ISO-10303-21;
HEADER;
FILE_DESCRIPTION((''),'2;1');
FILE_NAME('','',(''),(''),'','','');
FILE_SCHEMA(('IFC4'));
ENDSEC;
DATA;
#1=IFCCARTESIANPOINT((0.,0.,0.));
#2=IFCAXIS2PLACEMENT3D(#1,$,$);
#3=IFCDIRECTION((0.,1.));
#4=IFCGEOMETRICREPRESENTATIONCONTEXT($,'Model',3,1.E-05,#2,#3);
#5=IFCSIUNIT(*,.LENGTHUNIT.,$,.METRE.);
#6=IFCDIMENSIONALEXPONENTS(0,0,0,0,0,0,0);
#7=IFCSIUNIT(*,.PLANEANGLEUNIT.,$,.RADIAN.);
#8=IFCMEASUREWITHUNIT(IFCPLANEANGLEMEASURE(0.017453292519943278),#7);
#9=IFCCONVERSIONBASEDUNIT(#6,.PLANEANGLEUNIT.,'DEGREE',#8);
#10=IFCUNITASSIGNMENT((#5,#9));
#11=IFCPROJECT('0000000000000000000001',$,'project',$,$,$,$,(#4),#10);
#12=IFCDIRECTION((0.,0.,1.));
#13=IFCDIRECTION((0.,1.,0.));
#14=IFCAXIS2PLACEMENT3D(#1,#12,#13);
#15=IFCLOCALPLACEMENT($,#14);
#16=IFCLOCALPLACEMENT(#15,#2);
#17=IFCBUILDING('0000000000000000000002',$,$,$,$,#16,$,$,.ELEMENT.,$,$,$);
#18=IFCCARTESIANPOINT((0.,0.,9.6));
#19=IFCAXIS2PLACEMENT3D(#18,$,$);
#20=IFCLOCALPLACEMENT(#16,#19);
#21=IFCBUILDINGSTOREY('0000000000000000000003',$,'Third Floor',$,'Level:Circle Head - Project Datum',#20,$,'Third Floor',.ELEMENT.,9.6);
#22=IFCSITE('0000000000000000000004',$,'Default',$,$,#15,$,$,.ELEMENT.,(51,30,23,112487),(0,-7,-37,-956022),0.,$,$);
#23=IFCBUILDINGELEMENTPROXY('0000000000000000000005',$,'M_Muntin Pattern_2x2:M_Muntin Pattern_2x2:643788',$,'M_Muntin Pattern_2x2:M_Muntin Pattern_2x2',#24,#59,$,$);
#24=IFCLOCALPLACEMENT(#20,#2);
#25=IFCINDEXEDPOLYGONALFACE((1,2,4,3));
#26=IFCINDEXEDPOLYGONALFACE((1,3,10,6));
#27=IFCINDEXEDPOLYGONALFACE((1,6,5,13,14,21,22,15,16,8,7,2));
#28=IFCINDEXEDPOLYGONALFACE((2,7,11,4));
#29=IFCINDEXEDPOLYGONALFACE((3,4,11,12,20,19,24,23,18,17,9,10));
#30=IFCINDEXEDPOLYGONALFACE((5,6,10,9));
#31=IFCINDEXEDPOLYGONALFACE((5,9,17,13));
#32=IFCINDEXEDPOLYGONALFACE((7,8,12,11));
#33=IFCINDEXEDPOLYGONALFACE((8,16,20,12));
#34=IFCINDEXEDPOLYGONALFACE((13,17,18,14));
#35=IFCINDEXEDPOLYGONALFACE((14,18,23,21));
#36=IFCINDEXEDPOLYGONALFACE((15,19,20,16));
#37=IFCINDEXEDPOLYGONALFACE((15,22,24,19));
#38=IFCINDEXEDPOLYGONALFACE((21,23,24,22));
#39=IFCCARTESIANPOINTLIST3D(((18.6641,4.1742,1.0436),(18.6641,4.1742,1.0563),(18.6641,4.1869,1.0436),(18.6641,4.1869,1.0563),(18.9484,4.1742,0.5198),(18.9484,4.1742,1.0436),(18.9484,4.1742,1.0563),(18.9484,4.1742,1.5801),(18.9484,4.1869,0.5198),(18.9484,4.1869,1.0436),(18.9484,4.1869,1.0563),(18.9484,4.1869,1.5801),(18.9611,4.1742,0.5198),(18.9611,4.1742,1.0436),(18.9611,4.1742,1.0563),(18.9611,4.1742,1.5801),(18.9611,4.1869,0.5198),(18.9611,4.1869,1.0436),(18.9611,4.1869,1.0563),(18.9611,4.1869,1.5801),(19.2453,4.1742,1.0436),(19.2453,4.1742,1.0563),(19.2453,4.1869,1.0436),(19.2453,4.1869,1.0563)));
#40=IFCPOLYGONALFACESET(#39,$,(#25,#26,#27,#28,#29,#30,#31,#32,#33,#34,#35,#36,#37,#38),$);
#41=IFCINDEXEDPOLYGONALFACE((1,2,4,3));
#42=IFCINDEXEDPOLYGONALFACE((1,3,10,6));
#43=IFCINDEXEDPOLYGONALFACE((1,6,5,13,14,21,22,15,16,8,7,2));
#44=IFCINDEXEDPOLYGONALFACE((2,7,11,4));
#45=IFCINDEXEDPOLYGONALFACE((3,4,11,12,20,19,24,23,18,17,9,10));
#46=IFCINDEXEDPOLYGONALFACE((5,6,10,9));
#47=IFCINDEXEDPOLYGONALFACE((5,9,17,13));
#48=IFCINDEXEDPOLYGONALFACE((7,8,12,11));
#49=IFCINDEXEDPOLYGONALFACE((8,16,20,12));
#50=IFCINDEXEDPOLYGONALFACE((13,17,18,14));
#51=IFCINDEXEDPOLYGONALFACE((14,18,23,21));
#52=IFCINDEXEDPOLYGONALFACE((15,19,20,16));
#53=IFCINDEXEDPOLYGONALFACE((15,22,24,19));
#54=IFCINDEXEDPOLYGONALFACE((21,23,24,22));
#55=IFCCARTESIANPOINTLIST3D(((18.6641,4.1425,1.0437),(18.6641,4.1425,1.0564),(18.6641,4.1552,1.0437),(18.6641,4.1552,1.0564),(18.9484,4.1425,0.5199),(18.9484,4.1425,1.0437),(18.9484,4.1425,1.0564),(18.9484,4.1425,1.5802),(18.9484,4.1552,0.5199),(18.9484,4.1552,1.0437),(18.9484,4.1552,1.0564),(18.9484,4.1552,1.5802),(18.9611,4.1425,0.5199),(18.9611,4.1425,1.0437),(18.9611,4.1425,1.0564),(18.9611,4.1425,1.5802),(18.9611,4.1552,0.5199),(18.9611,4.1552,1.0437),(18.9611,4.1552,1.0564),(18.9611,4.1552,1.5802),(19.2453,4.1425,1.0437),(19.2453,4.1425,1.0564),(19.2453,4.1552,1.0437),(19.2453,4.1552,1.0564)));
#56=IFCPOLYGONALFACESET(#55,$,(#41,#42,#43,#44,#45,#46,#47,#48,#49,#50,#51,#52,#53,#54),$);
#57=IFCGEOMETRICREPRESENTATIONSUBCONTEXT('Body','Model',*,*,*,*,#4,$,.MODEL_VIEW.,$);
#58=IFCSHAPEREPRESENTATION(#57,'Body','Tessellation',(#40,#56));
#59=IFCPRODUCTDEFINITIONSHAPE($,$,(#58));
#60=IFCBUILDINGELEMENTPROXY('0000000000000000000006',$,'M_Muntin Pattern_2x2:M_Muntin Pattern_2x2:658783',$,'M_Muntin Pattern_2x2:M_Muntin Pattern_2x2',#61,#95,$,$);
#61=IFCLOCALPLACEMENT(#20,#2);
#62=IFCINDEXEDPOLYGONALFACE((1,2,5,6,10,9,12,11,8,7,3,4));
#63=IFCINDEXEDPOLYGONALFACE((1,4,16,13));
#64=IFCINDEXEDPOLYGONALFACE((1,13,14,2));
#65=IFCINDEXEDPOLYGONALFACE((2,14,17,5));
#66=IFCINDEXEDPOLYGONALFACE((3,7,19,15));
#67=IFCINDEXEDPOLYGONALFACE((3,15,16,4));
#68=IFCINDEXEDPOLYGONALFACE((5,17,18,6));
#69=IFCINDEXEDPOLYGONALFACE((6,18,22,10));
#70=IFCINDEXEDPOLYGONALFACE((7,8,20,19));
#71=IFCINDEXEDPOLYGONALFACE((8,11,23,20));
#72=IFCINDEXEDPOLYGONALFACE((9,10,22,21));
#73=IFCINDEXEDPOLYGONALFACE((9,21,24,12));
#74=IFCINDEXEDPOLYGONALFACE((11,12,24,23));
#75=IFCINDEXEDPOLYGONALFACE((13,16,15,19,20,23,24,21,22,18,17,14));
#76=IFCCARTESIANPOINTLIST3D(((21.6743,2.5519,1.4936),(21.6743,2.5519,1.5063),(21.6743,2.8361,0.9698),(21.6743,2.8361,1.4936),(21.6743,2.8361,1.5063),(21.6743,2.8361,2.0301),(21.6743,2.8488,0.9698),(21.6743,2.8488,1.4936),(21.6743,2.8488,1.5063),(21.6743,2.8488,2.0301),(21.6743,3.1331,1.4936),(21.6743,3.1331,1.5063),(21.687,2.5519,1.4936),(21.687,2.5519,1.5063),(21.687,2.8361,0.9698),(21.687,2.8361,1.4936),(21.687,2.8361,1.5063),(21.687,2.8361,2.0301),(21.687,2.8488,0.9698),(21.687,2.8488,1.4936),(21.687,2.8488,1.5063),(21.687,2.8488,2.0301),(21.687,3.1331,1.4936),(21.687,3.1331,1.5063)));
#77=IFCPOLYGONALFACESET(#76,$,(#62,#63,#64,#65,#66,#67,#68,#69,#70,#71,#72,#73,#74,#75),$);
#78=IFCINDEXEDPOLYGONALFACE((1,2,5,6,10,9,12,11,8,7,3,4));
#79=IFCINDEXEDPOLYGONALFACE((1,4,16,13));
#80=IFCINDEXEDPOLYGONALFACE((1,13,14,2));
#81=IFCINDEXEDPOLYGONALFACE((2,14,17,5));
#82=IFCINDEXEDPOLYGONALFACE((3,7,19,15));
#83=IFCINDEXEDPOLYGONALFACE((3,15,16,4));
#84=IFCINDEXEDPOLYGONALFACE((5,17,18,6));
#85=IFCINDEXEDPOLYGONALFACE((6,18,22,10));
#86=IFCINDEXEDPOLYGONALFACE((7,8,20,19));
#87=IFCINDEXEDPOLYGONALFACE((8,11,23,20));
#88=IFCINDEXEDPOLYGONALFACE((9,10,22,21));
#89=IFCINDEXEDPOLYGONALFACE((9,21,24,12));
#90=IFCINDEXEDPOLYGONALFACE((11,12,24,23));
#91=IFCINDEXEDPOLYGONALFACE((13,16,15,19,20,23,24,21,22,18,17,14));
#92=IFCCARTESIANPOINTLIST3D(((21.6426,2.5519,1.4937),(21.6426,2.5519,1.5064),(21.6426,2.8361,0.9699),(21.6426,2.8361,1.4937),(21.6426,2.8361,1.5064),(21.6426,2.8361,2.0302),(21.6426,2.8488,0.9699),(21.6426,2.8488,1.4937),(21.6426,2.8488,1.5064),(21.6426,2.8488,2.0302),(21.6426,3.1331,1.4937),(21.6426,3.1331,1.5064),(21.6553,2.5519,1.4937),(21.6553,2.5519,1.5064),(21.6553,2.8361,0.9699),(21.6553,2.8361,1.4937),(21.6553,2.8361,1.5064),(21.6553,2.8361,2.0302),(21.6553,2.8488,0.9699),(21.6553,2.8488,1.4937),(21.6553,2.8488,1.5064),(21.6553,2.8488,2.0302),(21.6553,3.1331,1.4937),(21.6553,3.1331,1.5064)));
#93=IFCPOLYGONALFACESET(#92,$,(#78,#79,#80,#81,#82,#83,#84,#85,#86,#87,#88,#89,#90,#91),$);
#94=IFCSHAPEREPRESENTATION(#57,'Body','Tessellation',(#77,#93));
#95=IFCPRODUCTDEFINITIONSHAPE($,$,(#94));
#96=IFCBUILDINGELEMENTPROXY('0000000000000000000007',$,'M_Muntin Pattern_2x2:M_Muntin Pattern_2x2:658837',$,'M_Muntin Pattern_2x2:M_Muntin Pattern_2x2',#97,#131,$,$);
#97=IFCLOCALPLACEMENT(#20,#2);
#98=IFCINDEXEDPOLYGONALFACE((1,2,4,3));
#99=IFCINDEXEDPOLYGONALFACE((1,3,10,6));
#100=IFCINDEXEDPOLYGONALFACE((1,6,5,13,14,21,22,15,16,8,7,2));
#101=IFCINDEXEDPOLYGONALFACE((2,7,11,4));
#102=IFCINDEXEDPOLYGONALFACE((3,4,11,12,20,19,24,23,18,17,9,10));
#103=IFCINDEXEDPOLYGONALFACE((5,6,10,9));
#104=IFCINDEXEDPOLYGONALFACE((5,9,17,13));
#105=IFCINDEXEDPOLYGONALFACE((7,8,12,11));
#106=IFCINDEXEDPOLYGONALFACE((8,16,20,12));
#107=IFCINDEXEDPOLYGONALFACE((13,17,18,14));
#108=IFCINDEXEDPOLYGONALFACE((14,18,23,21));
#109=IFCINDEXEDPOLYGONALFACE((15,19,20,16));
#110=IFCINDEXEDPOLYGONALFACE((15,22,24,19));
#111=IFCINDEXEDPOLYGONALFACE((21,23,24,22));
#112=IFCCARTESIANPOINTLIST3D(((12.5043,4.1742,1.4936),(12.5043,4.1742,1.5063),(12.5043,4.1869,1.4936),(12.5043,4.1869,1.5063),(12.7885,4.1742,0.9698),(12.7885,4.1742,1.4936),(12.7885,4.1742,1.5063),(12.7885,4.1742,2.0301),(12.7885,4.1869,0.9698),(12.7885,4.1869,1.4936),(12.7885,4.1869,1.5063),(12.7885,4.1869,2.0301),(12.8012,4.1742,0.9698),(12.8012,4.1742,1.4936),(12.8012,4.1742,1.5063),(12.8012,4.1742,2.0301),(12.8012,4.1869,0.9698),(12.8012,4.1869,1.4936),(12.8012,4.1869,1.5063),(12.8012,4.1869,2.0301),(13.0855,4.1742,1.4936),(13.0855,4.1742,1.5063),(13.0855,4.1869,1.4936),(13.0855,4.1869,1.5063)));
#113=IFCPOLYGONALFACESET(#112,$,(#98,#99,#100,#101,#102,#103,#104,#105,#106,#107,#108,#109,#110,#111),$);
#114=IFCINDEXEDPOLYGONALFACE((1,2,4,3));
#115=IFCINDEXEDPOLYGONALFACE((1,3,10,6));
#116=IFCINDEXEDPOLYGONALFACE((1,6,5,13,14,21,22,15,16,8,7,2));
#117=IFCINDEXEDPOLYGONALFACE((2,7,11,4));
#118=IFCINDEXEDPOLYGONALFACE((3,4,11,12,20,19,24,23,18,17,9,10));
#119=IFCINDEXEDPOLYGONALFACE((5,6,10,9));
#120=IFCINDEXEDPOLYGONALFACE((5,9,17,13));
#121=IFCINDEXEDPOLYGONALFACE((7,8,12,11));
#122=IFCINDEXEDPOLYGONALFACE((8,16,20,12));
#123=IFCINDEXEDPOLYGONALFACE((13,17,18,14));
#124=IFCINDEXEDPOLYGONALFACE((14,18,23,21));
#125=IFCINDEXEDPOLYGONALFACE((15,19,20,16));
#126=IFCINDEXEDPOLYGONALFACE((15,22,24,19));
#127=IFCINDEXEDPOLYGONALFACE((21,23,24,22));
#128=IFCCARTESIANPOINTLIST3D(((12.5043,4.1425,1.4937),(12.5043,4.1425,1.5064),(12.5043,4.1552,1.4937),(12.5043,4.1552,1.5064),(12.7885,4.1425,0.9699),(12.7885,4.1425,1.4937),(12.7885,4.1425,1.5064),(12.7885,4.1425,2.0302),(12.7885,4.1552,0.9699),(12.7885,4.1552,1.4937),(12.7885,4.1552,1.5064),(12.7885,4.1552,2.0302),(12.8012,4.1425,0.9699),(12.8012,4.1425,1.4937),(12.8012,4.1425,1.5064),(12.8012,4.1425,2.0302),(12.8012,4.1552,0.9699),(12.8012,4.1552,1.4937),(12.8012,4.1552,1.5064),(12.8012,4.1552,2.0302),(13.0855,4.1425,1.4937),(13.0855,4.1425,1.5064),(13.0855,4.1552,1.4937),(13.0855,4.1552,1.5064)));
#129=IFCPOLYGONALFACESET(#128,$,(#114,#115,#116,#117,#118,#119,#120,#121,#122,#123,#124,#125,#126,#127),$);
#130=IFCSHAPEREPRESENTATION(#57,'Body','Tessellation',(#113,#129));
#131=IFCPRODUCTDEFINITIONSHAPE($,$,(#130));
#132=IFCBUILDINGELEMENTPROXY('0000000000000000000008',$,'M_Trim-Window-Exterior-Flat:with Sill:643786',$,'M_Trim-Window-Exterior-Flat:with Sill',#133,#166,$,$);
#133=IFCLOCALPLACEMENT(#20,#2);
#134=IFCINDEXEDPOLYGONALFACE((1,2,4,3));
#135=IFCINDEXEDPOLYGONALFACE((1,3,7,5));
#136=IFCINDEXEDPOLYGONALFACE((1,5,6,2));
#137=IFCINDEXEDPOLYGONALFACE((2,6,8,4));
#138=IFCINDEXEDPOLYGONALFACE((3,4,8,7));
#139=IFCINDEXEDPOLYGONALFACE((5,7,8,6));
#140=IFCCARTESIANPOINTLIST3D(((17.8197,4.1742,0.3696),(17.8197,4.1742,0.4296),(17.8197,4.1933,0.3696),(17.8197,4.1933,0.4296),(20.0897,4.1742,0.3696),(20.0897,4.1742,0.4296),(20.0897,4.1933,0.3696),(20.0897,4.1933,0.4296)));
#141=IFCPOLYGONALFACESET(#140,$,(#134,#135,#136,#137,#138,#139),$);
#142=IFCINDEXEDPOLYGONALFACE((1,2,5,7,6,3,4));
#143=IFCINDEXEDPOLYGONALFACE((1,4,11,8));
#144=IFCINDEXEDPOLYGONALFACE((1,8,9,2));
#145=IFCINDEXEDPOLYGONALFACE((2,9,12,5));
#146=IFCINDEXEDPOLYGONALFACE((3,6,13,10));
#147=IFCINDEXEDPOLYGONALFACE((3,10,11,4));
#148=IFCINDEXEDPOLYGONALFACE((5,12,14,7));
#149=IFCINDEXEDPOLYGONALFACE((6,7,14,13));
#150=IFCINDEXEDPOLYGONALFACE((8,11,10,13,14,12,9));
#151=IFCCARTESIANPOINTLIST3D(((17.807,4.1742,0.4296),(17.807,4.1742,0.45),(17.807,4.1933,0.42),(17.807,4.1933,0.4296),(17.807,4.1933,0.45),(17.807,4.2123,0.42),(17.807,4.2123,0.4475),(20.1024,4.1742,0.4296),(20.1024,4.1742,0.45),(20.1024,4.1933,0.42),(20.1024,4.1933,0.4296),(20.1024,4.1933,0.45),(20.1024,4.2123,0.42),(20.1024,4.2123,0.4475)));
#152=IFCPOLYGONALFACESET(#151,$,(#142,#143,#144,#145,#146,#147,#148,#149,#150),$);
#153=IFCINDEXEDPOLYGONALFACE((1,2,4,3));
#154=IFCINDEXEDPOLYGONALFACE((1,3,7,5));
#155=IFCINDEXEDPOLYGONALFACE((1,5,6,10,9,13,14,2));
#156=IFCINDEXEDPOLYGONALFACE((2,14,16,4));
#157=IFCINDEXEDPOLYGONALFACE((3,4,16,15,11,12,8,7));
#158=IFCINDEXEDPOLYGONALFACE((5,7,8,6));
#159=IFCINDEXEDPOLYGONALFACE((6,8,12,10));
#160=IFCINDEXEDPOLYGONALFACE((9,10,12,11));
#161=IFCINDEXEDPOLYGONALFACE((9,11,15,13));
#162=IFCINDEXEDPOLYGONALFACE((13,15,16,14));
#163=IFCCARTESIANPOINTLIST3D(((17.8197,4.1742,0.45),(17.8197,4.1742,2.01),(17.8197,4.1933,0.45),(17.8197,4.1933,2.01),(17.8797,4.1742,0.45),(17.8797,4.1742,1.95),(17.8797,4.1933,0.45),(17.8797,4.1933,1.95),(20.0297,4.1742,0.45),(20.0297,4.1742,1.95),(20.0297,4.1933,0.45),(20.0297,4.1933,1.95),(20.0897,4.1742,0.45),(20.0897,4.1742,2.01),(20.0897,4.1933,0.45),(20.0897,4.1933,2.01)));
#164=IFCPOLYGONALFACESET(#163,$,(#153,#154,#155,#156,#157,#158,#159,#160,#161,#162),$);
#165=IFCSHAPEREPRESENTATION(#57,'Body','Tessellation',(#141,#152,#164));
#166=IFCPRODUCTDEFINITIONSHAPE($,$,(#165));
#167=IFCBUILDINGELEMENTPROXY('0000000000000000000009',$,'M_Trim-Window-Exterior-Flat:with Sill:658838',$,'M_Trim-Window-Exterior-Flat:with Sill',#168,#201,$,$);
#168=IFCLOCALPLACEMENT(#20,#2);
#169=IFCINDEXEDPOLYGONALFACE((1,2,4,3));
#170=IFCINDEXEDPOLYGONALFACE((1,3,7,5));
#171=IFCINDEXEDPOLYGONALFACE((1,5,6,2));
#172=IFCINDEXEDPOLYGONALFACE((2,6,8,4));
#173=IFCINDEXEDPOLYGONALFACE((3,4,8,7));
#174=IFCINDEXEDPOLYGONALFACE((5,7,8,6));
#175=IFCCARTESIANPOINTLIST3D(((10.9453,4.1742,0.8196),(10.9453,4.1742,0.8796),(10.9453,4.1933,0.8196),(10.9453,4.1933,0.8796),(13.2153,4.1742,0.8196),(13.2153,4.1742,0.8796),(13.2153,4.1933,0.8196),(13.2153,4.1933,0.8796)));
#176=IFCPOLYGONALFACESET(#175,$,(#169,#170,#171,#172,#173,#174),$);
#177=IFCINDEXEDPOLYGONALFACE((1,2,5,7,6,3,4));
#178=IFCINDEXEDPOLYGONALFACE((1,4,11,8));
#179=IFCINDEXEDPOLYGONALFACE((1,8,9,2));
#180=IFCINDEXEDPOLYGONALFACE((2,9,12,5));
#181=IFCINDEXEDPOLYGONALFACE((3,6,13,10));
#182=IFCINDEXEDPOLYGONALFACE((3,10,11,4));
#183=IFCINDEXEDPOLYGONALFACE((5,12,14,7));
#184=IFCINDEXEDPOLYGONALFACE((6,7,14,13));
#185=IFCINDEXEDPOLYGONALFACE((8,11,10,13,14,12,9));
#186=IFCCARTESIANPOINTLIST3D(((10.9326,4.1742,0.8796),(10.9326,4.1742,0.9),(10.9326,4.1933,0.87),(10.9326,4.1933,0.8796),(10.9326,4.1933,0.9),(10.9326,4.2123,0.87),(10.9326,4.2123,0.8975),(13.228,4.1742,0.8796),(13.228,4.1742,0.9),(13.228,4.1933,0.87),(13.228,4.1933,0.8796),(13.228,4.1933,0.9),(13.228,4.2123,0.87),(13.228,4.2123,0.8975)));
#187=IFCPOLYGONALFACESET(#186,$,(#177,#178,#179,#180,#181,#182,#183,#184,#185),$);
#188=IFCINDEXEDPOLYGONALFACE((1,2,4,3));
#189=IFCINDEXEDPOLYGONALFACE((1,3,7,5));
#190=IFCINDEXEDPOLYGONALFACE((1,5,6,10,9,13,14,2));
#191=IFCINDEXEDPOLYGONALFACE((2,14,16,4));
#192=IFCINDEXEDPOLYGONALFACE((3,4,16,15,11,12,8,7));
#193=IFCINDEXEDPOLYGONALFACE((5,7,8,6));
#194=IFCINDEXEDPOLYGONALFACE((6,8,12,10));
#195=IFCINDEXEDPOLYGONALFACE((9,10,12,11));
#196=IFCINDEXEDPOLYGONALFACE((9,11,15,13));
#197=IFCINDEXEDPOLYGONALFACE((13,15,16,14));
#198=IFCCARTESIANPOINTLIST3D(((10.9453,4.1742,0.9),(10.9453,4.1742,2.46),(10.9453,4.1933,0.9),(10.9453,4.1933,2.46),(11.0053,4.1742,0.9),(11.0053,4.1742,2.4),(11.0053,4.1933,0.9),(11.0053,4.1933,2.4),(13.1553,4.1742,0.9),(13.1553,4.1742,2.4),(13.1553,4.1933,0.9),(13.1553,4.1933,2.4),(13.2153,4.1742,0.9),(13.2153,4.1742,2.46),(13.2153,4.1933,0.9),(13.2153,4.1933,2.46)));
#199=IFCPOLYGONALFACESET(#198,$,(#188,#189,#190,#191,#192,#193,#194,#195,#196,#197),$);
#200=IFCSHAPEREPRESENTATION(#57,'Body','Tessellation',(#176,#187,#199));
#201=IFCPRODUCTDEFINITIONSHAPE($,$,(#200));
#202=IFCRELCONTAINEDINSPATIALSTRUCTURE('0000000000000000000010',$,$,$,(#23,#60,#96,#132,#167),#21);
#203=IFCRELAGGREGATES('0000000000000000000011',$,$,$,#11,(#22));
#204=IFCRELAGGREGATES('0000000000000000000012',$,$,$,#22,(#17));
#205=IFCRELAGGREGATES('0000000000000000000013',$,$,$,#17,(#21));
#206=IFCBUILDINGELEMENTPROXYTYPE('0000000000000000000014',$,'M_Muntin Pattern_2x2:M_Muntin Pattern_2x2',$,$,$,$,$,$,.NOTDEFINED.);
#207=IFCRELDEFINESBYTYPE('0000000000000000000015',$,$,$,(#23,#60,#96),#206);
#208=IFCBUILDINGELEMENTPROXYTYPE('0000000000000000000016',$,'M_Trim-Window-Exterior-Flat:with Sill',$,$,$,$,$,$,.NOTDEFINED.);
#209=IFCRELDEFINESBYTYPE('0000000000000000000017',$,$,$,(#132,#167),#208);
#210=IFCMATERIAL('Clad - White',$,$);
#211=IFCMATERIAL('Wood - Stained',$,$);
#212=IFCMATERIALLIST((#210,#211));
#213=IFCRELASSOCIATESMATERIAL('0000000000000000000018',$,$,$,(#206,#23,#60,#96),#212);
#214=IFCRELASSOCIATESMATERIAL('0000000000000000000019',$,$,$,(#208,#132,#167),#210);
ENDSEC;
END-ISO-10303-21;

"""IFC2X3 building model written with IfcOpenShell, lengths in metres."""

from ifc_helpers import new_model, entity, si_unit, converted_unit, direction, frame, frame_2d, origin, place, context, subcontext, project, spatial, polyline, rectangle, outline, extrude, source, transform, mapped, material, material_list, type_object, type_shapes, element, save


model = new_model("IFC2X3")

# Units and contexts
model_context = context("Model", 3, precision=1e-05, world=origin(), true_north=direction((0.0, 1.0)))
body_context = subcontext(model_context, "Body", "Model", "MODEL_VIEW")
ifc_project = project(units=[si_unit("LENGTHUNIT", "METRE"), converted_unit("PLANEANGLEUNIT", "DEGREE", entity("IfcPlaneAngleMeasure", 0.017453292519943278), si_unit("PLANEANGLEUNIT", "RADIAN"), dimensions=[0, 0, 0, 0, 0, 0, 0])], contexts=[model_context])

# Site, building, storey
site_placement = place(None, frame((0.0, 0.0, 0.0), z_axis=(0.0, 0.0, 1.0), x_axis=(0.0, 1.0, 0.0)))
site = spatial("IfcSite", under=ifc_project, at=site_placement, Name="Default", CompositionType="ELEMENT", RefLatitude=(51, 30, 23, 112487), RefLongitude=(0, -7, -37, -956022), RefElevation=0.0)
building_placement = place(site_placement, origin())
building = spatial("IfcBuilding", under=site, at=building_placement, CompositionType="ELEMENT")
storey_placement = place(building_placement, frame((0.0, 0.0, 9.6)))
storey = spatial("IfcBuildingStorey", under=building, at=storey_placement, Name="Third Floor", ObjectType="Level:Circle Head - Project Datum", LongName="Third Floor", CompositionType="ELEMENT", Elevation=9.6)

# Building element proxies
ifc_material_1 = material(Name="Clad - White")
ifc_material_2 = material(Name="Wood - Stained")
ifc_material_list = material_list([ifc_material_1, ifc_material_2])
building_element_proxy_type_1 = type_object("IfcBuildingElementProxyType", Name="M_Muntin Pattern_2x2:M_Muntin Pattern_2x2", PredefinedType="NOTDEFINED", material=ifc_material_list)
shared_shape_1 = source(origin(), body_context, "Body", "SweptSolid", [
    extrude(outline(polyline([(0.0064, -0.0064), (0.5301, -0.0064), (0.5301, 0.0063), (0.0064, 0.0063), (0.0064, 0.2906), (-0.0063, 0.2906), (-0.0063, 0.0063), (-0.5302, 0.0063), (-0.5302, -0.0064), (-0.0063, -0.0064), (-0.0063, -0.2906), (0.0064, -0.2906), (0.0064, -0.0064)])), frame((0.0, -0.0222, 0.5301), z_axis=(0.0, 1.0, 0.0), x_axis=(0.0, 0.0, 1.0)), (0.0, 0.0, 1.0), 0.0127),
    extrude(outline(polyline([(0.0064, -0.0064), (0.5302, -0.0064), (0.5302, 0.0063), (0.0064, 0.0063), (0.0064, 0.2906), (-0.0063, 0.2906), (-0.0063, 0.0063), (-0.5302, 0.0063), (-0.5302, -0.0064), (-0.0063, -0.0064), (-0.0063, -0.2906), (0.0064, -0.2906), (0.0064, -0.0064)])), frame((0.0, 0.0095, 0.5302), z_axis=(0.0, 1.0, 0.0), x_axis=(0.0, 0.0, 1.0)), (0.0, 0.0, 1.0), 0.0127),
])
type_shapes(building_element_proxy_type_1, [shared_shape_1])
for number, where, z_axis, x_axis, name in (
    (1, (18.9547, 4.1647, 0.5199), (0.0, 0.0, 1.0), (-1.0, 0.0, 0.0), "M_Muntin Pattern_2x2:M_Muntin Pattern_2x2:643788"),
    (2, (21.6648, 2.8425, 0.9699), (0.0, 0.0, 1.0), (0.0, 1.0, 0.0), "M_Muntin Pattern_2x2:M_Muntin Pattern_2x2:658783"),
    (3, (12.7949, 4.1647, 0.9699), (0.0, 0.0, 1.0), (-1.0, 0.0, 0.0), "M_Muntin Pattern_2x2:M_Muntin Pattern_2x2:658837"),
):
    element("IfcBuildingElementProxy", number, at=place(storey_placement, frame(where, z_axis=z_axis, x_axis=x_axis)), inside=storey, type_object=building_element_proxy_type_1, material=ifc_material_list, Name=name, ObjectType="M_Muntin Pattern_2x2:M_Muntin Pattern_2x2", context=body_context, shape_type="MappedRepresentation", body=[
        mapped(shared_shape_1, transform((0.0, 0.0, 0.0), scale=1.0)),
    ])
building_element_proxy_type_2 = type_object("IfcBuildingElementProxyType", Name="M_Trim-Window-Exterior-Flat:with Sill", PredefinedType="NOTDEFINED", material=ifc_material_1)
shared_shape_2 = source(origin(), body_context, "Body", "SweptSolid", [
    extrude(rectangle(XDim=2.27, YDim=0.06, at=frame_2d((0.0, 0.0), x_axis=(1.0, 0.0))), frame((0.0, -1.5504, 0.0), z_axis=(0.0, 0.0, 1.0), x_axis=(-1.0, 0.0, 0.0)), (0.0, 0.0, 1.0), 0.019),
    extrude(outline(polyline([(-0.019, -0.0152), (0.0, -0.0152), (0.0, -0.0057), (0.019, -0.0057), (0.019, 0.0148), (0.0, 0.0148), (-0.019, 0.0123), (-0.019, -0.0152)])), frame((-1.1477, -1.5148, 0.019), z_axis=(1.0, 0.0, 0.0), x_axis=(0.0, 0.0, -1.0)), (0.0, 0.0, 1.0), 2.2954),
    extrude(outline(polyline([(-0.795, -1.135), (0.765, -1.135), (0.765, -1.075), (-0.735, -1.075), (-0.735, 1.075), (0.765, 1.075), (0.765, 1.135), (-0.795, 1.135), (-0.795, -1.135)])), frame((0.0, -0.735, 0.0), z_axis=(0.0, 0.0, 1.0), x_axis=(0.0, -1.0, 0.0)), (0.0, 0.0, 1.0), 0.019),
])
type_shapes(building_element_proxy_type_2, [shared_shape_2])
for number, where, z_axis, x_axis, name in (
    (4, (18.9547, 4.1742, 1.95), (0.0, 1.0, 0.0), (-1.0, 0.0, 0.0), "M_Trim-Window-Exterior-Flat:with Sill:643786"),
    (5, (12.0803, 4.1742, 2.4), (0.0, 1.0, 0.0), (-1.0, 0.0, 0.0), "M_Trim-Window-Exterior-Flat:with Sill:658838"),
):
    element("IfcBuildingElementProxy", number, at=place(storey_placement, frame(where, z_axis=z_axis, x_axis=x_axis)), inside=storey, type_object=building_element_proxy_type_2, material=ifc_material_1, Name=name, ObjectType="M_Trim-Window-Exterior-Flat:with Sill", context=body_context, shape_type="MappedRepresentation", body=[
        mapped(shared_shape_2, transform((0.0, 0.0, 0.0), scale=1.0)),
    ])

save(model, "model.ifc")
